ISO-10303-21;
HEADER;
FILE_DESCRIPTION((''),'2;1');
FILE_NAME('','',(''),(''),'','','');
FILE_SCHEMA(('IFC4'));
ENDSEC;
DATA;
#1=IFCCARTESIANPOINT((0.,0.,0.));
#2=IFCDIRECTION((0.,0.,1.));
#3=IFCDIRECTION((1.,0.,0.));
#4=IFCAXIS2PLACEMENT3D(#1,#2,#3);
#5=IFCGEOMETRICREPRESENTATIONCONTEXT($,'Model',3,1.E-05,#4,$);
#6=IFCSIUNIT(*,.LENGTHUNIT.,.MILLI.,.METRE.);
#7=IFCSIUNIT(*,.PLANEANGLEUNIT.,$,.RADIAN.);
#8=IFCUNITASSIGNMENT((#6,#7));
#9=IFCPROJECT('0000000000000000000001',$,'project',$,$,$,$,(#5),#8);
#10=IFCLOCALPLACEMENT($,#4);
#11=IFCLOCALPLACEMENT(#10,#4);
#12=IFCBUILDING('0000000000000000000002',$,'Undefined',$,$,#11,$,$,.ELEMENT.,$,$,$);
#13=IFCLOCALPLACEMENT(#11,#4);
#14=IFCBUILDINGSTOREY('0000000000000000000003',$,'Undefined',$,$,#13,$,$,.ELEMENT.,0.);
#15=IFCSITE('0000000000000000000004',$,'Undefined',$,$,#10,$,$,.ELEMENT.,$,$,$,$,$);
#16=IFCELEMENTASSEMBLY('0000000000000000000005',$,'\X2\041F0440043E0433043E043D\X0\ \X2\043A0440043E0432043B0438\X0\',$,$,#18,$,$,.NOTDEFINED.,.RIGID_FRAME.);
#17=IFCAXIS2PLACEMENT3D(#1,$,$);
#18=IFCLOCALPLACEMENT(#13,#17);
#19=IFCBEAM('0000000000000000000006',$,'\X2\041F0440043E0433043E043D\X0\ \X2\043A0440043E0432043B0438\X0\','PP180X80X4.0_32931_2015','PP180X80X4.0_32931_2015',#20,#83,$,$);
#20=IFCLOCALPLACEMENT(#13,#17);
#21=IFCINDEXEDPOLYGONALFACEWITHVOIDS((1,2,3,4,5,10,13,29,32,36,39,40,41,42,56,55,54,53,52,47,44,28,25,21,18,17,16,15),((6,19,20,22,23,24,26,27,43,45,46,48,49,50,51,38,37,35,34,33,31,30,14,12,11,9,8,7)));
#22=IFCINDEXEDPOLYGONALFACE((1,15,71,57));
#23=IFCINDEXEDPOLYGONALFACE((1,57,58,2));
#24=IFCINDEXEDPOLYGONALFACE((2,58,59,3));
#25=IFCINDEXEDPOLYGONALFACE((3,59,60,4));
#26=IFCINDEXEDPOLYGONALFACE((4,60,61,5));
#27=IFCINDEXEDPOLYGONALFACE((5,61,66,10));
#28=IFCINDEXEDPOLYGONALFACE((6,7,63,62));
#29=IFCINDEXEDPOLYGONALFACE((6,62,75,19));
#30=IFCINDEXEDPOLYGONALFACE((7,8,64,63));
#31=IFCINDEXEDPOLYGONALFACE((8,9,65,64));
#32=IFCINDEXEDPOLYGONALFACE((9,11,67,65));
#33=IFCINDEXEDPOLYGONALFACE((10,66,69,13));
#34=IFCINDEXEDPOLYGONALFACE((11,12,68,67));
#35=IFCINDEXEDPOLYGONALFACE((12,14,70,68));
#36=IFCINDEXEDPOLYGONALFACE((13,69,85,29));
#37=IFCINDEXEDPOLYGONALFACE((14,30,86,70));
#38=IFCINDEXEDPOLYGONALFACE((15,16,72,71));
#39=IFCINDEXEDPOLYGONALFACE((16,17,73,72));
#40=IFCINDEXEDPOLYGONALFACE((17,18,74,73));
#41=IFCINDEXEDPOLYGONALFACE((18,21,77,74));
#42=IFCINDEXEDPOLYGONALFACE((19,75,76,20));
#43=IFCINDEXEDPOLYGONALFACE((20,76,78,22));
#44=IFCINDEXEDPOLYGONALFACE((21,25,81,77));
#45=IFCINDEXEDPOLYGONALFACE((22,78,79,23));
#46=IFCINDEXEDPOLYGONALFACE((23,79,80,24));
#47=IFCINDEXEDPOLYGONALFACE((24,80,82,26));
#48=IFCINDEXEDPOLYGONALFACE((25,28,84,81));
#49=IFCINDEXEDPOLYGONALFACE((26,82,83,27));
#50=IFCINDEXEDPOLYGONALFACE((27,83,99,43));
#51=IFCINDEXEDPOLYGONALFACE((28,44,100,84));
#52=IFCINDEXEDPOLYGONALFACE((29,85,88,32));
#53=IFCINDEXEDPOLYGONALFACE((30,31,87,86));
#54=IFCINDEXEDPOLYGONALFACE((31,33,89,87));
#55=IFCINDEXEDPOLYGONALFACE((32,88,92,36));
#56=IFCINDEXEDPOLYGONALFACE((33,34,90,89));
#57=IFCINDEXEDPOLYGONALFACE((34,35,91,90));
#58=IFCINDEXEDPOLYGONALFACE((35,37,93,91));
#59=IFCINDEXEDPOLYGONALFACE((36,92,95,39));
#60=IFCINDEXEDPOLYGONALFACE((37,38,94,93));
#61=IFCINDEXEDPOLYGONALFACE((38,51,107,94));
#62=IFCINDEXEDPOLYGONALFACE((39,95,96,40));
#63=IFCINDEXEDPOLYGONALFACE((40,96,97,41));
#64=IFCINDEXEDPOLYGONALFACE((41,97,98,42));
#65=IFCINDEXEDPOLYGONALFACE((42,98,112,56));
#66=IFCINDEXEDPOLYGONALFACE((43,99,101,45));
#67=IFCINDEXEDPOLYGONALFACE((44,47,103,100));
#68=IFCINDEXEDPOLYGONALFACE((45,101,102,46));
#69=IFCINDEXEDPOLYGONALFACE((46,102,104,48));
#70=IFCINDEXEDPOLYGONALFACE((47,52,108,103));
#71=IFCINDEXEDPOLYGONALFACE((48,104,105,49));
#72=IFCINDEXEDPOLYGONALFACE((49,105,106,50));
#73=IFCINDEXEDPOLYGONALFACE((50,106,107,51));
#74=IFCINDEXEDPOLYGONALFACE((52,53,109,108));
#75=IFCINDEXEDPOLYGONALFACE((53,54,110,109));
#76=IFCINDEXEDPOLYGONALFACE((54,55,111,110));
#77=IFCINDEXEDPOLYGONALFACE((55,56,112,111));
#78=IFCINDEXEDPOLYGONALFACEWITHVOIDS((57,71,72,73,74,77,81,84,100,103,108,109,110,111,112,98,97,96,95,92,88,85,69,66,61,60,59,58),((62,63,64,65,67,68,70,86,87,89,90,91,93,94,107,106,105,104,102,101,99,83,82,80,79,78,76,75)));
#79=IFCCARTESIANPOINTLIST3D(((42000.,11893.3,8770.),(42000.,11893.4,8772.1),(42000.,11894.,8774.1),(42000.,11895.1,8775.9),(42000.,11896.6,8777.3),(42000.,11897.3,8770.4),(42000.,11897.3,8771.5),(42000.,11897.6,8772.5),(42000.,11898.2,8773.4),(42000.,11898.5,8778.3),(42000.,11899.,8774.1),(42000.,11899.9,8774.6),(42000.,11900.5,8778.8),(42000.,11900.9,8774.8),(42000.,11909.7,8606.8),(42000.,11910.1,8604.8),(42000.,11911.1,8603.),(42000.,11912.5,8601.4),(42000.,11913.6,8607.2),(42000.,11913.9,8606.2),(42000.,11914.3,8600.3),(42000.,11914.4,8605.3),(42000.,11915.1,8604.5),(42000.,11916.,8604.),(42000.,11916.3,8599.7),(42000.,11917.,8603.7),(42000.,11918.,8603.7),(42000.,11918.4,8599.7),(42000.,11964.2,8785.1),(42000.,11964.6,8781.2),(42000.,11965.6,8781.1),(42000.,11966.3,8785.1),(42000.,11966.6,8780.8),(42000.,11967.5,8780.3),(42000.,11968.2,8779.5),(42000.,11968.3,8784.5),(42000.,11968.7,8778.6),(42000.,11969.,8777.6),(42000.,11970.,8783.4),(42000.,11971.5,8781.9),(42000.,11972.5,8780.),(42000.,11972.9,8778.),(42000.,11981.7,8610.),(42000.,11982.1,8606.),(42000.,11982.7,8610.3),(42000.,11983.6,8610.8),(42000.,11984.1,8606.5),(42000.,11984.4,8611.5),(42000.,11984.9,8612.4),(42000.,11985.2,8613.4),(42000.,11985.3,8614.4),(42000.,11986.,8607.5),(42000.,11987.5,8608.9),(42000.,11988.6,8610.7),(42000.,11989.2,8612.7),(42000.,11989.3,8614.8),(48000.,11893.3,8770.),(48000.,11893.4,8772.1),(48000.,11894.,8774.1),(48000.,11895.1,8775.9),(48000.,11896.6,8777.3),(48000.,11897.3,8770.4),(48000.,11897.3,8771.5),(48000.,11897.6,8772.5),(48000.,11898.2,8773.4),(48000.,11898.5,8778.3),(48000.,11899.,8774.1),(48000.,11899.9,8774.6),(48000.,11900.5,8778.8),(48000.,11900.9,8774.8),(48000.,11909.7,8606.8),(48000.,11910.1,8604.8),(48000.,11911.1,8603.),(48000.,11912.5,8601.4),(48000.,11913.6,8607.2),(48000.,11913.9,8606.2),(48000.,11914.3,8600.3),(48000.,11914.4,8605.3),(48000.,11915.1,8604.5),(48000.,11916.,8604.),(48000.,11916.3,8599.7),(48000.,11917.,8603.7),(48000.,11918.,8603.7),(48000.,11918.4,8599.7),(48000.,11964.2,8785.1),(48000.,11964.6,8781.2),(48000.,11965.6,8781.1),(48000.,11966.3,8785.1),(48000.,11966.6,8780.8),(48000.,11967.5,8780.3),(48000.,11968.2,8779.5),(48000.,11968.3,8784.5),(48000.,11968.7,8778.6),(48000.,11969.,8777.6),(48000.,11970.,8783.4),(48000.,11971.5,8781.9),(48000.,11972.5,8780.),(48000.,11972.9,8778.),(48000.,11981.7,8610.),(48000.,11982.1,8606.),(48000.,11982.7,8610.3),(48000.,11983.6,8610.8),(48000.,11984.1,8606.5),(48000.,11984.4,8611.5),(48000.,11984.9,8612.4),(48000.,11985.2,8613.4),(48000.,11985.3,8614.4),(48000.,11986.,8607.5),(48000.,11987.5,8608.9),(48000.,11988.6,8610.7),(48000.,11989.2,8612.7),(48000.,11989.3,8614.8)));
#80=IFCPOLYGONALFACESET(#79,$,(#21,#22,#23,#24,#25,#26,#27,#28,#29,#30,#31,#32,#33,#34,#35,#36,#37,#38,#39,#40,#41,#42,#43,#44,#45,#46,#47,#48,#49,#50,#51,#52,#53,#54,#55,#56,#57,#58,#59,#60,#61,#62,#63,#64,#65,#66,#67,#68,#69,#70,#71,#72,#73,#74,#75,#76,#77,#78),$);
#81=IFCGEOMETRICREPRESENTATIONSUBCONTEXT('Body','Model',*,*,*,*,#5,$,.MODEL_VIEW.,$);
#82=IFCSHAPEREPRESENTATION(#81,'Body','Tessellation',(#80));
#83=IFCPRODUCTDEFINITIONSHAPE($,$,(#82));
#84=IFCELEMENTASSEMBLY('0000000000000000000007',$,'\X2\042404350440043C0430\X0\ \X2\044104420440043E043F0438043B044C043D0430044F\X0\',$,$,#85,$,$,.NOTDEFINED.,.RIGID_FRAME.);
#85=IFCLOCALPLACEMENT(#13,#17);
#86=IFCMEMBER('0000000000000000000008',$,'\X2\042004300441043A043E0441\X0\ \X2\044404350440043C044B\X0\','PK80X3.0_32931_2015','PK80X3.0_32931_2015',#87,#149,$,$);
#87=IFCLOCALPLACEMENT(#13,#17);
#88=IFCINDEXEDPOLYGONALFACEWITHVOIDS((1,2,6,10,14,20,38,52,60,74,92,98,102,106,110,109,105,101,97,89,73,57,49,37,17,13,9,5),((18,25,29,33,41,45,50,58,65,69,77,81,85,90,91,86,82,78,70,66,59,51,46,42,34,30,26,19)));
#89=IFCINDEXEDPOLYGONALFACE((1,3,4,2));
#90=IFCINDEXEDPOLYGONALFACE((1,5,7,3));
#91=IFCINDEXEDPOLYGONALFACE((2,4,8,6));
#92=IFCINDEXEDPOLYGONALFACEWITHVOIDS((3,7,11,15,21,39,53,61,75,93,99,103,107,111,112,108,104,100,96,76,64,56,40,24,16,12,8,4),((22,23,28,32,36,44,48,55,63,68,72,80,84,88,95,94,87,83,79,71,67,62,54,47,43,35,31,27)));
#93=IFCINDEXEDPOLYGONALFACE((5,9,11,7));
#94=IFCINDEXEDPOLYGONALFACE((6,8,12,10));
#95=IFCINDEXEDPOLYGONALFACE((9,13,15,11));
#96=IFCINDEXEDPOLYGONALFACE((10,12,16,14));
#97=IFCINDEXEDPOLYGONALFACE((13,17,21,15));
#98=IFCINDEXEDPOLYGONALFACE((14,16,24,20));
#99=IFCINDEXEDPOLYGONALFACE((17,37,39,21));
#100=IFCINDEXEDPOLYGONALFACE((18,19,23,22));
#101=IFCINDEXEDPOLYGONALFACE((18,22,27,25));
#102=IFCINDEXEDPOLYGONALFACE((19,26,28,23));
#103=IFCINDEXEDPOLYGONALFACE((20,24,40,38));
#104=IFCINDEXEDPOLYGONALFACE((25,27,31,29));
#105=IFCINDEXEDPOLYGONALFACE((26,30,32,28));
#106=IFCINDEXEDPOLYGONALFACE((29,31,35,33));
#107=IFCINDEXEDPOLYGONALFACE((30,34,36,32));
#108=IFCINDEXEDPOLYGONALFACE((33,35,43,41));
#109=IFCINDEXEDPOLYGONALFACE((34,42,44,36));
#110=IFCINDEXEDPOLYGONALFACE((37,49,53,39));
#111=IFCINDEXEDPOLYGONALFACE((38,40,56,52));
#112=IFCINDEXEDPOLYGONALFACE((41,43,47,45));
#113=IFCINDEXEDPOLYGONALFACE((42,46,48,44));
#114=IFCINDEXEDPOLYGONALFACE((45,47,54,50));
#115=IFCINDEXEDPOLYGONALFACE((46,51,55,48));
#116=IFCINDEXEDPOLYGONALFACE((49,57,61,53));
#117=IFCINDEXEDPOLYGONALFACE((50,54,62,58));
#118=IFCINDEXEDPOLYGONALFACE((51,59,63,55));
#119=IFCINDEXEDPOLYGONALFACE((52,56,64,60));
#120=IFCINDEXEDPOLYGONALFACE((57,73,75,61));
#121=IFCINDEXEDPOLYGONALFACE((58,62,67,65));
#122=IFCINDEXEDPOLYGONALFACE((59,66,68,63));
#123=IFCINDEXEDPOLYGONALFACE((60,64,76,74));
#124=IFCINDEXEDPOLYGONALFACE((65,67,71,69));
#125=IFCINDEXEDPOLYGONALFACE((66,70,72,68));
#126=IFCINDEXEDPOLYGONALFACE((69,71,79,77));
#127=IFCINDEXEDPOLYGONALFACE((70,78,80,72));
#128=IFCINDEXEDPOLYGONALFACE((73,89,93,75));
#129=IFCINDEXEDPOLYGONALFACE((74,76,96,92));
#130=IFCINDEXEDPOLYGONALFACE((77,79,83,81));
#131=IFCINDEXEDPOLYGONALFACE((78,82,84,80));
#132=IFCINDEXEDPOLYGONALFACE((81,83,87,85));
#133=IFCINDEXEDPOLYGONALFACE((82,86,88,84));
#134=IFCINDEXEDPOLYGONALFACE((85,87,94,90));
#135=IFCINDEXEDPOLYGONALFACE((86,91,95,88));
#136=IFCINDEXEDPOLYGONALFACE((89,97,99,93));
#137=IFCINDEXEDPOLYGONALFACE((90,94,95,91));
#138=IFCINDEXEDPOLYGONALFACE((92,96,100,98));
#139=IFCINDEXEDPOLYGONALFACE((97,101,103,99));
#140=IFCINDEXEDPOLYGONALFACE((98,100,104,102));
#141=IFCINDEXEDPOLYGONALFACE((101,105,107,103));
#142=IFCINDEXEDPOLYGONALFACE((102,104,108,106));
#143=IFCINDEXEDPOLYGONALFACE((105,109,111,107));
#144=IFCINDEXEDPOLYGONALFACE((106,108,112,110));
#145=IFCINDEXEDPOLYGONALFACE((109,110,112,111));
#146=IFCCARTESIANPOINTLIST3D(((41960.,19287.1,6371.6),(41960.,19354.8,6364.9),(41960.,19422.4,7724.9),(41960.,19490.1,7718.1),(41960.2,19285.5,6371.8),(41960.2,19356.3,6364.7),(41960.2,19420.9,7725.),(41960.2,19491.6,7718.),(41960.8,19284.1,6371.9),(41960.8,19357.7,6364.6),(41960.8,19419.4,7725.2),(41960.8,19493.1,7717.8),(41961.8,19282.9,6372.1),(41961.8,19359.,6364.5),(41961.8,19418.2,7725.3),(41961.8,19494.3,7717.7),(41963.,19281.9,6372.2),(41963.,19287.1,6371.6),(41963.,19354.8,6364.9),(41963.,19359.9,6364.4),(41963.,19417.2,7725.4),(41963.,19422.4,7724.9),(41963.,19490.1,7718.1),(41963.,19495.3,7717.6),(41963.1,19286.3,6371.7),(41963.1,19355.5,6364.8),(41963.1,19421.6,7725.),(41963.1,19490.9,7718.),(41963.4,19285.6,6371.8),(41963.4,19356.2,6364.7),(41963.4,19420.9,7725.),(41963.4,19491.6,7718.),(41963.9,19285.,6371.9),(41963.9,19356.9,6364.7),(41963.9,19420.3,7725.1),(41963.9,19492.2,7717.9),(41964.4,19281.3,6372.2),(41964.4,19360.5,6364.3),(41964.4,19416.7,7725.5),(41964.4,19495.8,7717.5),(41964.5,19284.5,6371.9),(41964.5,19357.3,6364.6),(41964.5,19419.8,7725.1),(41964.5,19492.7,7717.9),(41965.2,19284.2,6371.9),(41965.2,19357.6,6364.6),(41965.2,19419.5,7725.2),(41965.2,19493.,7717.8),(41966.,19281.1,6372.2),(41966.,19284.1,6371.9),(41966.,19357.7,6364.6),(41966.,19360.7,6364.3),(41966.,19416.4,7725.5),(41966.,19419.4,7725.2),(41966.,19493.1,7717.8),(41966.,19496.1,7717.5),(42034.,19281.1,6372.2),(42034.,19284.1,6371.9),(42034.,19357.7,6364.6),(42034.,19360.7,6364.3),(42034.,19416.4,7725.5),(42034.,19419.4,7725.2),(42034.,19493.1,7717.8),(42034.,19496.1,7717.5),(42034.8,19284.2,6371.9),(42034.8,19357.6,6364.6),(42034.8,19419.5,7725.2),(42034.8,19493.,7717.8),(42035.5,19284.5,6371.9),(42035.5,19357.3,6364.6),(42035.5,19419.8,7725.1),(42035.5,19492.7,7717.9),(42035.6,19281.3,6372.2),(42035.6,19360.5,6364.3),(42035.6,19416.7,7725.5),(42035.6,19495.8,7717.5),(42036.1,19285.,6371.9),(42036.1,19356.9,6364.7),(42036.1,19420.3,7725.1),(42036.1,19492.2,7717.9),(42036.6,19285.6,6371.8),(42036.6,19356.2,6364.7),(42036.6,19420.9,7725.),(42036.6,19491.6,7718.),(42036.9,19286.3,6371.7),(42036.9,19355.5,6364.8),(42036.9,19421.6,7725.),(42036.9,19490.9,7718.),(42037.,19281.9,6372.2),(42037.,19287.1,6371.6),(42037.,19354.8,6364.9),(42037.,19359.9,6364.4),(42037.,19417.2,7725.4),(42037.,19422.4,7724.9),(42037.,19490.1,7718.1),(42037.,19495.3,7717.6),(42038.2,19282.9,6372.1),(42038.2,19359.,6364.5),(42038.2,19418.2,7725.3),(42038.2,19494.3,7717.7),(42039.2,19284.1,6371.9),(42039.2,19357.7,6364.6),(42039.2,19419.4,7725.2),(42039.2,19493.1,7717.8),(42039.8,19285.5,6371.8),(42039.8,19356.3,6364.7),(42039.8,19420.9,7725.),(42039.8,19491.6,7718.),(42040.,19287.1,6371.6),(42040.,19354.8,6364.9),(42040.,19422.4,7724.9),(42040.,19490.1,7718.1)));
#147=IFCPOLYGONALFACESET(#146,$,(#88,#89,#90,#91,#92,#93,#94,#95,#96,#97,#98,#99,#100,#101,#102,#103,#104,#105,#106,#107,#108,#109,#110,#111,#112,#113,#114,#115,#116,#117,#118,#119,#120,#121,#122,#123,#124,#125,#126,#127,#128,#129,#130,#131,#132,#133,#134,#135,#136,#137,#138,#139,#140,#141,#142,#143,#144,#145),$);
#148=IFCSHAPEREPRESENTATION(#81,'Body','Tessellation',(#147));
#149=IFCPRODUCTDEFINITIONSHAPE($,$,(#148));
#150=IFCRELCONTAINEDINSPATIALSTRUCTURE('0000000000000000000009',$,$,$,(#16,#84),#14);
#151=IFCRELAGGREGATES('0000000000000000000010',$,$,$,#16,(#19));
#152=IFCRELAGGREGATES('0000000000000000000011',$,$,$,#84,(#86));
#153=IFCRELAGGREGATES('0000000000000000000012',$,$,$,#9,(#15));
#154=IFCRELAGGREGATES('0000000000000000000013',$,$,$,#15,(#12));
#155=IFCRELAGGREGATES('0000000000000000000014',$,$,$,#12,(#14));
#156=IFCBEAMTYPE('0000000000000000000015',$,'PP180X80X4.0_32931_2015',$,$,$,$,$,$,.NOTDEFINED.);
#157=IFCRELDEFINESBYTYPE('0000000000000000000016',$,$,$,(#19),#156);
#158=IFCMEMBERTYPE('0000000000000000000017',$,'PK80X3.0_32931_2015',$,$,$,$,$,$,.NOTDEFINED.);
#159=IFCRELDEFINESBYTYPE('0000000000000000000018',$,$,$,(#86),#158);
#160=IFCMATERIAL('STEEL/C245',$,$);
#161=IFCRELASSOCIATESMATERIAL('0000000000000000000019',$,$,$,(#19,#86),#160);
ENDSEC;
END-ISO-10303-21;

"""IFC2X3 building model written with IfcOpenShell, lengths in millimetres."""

from ifc_helpers import new_model, si_unit, frame, origin_with_axes, origin_2d_with_axis, place, context, subcontext, project, spatial, hollow_rectangle, extrude, material, type_object, element, aggregate, save


model = new_model("IFC2X3")

# Units and contexts
model_context = context("Model", 3, precision=1e-05, world=origin_with_axes())
body_context = subcontext(model_context, "Body", "Model", "MODEL_VIEW")
ifc_project = project(units=[si_unit("LENGTHUNIT", "METRE", prefix="MILLI"), si_unit("PLANEANGLEUNIT", "RADIAN")], contexts=[model_context])

# Site, building, storey
site_placement = place(None, origin_with_axes())
site = spatial("IfcSite", under=ifc_project, at=site_placement, Name="Undefined", CompositionType="ELEMENT")
building_placement = place(site_placement, origin_with_axes())
building = spatial("IfcBuilding", under=site, at=building_placement, Name="Undefined", CompositionType="ELEMENT")
storey_placement = place(building_placement, origin_with_axes())
storey = spatial("IfcBuildingStorey", under=building, at=storey_placement, Name="Undefined", CompositionType="ELEMENT", Elevation=0.0)

# Element assembly, beam
ifc_material_1 = material(Name="STEEL/C245")
beam_type_1 = type_object("IfcBeamType", Name="PP180X80X4.0_32931_2015", PredefinedType="NOTDEFINED")
assembly_1_placement = place(storey_placement, origin_with_axes())
assembly_1 = element("IfcElementAssembly", 1, at=assembly_1_placement, inside=storey, Name="Прогон кровли", AssemblyPlace="NOTDEFINED", PredefinedType="RIGID_FRAME")
beam_1_placement = place(assembly_1_placement, frame((42000.0, 11941.3, 8692.4), z_axis=(0.0, -0.099504, 0.995037), x_axis=(1.0, 0.0, 0.0)))
beam_1 = element("IfcBeam", 2, at=beam_1_placement, type_object=beam_type_1, material=ifc_material_1, Name="Прогон кровли", Description="PP180X80X4.0_32931_2015", ObjectType="PP180X80X4.0_32931_2015", context=body_context, shape_type="SweptSolid", body=[
    extrude(hollow_rectangle(XDim=80.0, YDim=180.0, WallThickness=4.0, InnerFilletRadius=4.0, OuterFilletRadius=8.0, at=origin_2d_with_axis()), frame((6000.0, 0.0, 0.0), z_axis=(-1.0, 0.0, 0.0), x_axis=(0.0, -1.0, 0.0)), (0.0, 0.0, 1.0), 6000.0),
])
aggregate(assembly_1, [beam_1])

# Shared definitions
member_type_1 = type_object("IfcMemberType", Name="PK80X3.0_32931_2015", PredefinedType="NOTDEFINED")

# Element assembly, member
assembly_2_placement = place(storey_placement, origin_with_axes())
assembly_2 = element("IfcElementAssembly", 3, at=assembly_2_placement, inside=storey, Name="Ферма стропильная", AssemblyPlace="NOTDEFINED", PredefinedType="RIGID_FRAME")
member_1_placement = place(assembly_2_placement, frame((42000.0, 19456.2, 7721.5), z_axis=(0.0, -0.995037, 0.099504), x_axis=(0.0, -0.099504, -0.995037)))
member_1 = element("IfcMember", 4, at=member_1_placement, type_object=member_type_1, material=ifc_material_1, Name="Раскос фермы", Description="PK80X3.0_32931_2015", ObjectType="PK80X3.0_32931_2015", context=body_context, shape_type="SweptSolid", body=[
    extrude(hollow_rectangle(XDim=80.0, YDim=80.0, WallThickness=3.0, InnerFilletRadius=3.0, OuterFilletRadius=6.0, at=origin_2d_with_axis()), frame((1360.0, 0.0, 0.0), z_axis=(-1.0, 0.0, 0.0), x_axis=(0.0, -1.0, 0.0)), (0.0, 0.0, 1.0), 1360.0),
])

aggregate(assembly_2, [member_1])

save(model, "model.ifc")
